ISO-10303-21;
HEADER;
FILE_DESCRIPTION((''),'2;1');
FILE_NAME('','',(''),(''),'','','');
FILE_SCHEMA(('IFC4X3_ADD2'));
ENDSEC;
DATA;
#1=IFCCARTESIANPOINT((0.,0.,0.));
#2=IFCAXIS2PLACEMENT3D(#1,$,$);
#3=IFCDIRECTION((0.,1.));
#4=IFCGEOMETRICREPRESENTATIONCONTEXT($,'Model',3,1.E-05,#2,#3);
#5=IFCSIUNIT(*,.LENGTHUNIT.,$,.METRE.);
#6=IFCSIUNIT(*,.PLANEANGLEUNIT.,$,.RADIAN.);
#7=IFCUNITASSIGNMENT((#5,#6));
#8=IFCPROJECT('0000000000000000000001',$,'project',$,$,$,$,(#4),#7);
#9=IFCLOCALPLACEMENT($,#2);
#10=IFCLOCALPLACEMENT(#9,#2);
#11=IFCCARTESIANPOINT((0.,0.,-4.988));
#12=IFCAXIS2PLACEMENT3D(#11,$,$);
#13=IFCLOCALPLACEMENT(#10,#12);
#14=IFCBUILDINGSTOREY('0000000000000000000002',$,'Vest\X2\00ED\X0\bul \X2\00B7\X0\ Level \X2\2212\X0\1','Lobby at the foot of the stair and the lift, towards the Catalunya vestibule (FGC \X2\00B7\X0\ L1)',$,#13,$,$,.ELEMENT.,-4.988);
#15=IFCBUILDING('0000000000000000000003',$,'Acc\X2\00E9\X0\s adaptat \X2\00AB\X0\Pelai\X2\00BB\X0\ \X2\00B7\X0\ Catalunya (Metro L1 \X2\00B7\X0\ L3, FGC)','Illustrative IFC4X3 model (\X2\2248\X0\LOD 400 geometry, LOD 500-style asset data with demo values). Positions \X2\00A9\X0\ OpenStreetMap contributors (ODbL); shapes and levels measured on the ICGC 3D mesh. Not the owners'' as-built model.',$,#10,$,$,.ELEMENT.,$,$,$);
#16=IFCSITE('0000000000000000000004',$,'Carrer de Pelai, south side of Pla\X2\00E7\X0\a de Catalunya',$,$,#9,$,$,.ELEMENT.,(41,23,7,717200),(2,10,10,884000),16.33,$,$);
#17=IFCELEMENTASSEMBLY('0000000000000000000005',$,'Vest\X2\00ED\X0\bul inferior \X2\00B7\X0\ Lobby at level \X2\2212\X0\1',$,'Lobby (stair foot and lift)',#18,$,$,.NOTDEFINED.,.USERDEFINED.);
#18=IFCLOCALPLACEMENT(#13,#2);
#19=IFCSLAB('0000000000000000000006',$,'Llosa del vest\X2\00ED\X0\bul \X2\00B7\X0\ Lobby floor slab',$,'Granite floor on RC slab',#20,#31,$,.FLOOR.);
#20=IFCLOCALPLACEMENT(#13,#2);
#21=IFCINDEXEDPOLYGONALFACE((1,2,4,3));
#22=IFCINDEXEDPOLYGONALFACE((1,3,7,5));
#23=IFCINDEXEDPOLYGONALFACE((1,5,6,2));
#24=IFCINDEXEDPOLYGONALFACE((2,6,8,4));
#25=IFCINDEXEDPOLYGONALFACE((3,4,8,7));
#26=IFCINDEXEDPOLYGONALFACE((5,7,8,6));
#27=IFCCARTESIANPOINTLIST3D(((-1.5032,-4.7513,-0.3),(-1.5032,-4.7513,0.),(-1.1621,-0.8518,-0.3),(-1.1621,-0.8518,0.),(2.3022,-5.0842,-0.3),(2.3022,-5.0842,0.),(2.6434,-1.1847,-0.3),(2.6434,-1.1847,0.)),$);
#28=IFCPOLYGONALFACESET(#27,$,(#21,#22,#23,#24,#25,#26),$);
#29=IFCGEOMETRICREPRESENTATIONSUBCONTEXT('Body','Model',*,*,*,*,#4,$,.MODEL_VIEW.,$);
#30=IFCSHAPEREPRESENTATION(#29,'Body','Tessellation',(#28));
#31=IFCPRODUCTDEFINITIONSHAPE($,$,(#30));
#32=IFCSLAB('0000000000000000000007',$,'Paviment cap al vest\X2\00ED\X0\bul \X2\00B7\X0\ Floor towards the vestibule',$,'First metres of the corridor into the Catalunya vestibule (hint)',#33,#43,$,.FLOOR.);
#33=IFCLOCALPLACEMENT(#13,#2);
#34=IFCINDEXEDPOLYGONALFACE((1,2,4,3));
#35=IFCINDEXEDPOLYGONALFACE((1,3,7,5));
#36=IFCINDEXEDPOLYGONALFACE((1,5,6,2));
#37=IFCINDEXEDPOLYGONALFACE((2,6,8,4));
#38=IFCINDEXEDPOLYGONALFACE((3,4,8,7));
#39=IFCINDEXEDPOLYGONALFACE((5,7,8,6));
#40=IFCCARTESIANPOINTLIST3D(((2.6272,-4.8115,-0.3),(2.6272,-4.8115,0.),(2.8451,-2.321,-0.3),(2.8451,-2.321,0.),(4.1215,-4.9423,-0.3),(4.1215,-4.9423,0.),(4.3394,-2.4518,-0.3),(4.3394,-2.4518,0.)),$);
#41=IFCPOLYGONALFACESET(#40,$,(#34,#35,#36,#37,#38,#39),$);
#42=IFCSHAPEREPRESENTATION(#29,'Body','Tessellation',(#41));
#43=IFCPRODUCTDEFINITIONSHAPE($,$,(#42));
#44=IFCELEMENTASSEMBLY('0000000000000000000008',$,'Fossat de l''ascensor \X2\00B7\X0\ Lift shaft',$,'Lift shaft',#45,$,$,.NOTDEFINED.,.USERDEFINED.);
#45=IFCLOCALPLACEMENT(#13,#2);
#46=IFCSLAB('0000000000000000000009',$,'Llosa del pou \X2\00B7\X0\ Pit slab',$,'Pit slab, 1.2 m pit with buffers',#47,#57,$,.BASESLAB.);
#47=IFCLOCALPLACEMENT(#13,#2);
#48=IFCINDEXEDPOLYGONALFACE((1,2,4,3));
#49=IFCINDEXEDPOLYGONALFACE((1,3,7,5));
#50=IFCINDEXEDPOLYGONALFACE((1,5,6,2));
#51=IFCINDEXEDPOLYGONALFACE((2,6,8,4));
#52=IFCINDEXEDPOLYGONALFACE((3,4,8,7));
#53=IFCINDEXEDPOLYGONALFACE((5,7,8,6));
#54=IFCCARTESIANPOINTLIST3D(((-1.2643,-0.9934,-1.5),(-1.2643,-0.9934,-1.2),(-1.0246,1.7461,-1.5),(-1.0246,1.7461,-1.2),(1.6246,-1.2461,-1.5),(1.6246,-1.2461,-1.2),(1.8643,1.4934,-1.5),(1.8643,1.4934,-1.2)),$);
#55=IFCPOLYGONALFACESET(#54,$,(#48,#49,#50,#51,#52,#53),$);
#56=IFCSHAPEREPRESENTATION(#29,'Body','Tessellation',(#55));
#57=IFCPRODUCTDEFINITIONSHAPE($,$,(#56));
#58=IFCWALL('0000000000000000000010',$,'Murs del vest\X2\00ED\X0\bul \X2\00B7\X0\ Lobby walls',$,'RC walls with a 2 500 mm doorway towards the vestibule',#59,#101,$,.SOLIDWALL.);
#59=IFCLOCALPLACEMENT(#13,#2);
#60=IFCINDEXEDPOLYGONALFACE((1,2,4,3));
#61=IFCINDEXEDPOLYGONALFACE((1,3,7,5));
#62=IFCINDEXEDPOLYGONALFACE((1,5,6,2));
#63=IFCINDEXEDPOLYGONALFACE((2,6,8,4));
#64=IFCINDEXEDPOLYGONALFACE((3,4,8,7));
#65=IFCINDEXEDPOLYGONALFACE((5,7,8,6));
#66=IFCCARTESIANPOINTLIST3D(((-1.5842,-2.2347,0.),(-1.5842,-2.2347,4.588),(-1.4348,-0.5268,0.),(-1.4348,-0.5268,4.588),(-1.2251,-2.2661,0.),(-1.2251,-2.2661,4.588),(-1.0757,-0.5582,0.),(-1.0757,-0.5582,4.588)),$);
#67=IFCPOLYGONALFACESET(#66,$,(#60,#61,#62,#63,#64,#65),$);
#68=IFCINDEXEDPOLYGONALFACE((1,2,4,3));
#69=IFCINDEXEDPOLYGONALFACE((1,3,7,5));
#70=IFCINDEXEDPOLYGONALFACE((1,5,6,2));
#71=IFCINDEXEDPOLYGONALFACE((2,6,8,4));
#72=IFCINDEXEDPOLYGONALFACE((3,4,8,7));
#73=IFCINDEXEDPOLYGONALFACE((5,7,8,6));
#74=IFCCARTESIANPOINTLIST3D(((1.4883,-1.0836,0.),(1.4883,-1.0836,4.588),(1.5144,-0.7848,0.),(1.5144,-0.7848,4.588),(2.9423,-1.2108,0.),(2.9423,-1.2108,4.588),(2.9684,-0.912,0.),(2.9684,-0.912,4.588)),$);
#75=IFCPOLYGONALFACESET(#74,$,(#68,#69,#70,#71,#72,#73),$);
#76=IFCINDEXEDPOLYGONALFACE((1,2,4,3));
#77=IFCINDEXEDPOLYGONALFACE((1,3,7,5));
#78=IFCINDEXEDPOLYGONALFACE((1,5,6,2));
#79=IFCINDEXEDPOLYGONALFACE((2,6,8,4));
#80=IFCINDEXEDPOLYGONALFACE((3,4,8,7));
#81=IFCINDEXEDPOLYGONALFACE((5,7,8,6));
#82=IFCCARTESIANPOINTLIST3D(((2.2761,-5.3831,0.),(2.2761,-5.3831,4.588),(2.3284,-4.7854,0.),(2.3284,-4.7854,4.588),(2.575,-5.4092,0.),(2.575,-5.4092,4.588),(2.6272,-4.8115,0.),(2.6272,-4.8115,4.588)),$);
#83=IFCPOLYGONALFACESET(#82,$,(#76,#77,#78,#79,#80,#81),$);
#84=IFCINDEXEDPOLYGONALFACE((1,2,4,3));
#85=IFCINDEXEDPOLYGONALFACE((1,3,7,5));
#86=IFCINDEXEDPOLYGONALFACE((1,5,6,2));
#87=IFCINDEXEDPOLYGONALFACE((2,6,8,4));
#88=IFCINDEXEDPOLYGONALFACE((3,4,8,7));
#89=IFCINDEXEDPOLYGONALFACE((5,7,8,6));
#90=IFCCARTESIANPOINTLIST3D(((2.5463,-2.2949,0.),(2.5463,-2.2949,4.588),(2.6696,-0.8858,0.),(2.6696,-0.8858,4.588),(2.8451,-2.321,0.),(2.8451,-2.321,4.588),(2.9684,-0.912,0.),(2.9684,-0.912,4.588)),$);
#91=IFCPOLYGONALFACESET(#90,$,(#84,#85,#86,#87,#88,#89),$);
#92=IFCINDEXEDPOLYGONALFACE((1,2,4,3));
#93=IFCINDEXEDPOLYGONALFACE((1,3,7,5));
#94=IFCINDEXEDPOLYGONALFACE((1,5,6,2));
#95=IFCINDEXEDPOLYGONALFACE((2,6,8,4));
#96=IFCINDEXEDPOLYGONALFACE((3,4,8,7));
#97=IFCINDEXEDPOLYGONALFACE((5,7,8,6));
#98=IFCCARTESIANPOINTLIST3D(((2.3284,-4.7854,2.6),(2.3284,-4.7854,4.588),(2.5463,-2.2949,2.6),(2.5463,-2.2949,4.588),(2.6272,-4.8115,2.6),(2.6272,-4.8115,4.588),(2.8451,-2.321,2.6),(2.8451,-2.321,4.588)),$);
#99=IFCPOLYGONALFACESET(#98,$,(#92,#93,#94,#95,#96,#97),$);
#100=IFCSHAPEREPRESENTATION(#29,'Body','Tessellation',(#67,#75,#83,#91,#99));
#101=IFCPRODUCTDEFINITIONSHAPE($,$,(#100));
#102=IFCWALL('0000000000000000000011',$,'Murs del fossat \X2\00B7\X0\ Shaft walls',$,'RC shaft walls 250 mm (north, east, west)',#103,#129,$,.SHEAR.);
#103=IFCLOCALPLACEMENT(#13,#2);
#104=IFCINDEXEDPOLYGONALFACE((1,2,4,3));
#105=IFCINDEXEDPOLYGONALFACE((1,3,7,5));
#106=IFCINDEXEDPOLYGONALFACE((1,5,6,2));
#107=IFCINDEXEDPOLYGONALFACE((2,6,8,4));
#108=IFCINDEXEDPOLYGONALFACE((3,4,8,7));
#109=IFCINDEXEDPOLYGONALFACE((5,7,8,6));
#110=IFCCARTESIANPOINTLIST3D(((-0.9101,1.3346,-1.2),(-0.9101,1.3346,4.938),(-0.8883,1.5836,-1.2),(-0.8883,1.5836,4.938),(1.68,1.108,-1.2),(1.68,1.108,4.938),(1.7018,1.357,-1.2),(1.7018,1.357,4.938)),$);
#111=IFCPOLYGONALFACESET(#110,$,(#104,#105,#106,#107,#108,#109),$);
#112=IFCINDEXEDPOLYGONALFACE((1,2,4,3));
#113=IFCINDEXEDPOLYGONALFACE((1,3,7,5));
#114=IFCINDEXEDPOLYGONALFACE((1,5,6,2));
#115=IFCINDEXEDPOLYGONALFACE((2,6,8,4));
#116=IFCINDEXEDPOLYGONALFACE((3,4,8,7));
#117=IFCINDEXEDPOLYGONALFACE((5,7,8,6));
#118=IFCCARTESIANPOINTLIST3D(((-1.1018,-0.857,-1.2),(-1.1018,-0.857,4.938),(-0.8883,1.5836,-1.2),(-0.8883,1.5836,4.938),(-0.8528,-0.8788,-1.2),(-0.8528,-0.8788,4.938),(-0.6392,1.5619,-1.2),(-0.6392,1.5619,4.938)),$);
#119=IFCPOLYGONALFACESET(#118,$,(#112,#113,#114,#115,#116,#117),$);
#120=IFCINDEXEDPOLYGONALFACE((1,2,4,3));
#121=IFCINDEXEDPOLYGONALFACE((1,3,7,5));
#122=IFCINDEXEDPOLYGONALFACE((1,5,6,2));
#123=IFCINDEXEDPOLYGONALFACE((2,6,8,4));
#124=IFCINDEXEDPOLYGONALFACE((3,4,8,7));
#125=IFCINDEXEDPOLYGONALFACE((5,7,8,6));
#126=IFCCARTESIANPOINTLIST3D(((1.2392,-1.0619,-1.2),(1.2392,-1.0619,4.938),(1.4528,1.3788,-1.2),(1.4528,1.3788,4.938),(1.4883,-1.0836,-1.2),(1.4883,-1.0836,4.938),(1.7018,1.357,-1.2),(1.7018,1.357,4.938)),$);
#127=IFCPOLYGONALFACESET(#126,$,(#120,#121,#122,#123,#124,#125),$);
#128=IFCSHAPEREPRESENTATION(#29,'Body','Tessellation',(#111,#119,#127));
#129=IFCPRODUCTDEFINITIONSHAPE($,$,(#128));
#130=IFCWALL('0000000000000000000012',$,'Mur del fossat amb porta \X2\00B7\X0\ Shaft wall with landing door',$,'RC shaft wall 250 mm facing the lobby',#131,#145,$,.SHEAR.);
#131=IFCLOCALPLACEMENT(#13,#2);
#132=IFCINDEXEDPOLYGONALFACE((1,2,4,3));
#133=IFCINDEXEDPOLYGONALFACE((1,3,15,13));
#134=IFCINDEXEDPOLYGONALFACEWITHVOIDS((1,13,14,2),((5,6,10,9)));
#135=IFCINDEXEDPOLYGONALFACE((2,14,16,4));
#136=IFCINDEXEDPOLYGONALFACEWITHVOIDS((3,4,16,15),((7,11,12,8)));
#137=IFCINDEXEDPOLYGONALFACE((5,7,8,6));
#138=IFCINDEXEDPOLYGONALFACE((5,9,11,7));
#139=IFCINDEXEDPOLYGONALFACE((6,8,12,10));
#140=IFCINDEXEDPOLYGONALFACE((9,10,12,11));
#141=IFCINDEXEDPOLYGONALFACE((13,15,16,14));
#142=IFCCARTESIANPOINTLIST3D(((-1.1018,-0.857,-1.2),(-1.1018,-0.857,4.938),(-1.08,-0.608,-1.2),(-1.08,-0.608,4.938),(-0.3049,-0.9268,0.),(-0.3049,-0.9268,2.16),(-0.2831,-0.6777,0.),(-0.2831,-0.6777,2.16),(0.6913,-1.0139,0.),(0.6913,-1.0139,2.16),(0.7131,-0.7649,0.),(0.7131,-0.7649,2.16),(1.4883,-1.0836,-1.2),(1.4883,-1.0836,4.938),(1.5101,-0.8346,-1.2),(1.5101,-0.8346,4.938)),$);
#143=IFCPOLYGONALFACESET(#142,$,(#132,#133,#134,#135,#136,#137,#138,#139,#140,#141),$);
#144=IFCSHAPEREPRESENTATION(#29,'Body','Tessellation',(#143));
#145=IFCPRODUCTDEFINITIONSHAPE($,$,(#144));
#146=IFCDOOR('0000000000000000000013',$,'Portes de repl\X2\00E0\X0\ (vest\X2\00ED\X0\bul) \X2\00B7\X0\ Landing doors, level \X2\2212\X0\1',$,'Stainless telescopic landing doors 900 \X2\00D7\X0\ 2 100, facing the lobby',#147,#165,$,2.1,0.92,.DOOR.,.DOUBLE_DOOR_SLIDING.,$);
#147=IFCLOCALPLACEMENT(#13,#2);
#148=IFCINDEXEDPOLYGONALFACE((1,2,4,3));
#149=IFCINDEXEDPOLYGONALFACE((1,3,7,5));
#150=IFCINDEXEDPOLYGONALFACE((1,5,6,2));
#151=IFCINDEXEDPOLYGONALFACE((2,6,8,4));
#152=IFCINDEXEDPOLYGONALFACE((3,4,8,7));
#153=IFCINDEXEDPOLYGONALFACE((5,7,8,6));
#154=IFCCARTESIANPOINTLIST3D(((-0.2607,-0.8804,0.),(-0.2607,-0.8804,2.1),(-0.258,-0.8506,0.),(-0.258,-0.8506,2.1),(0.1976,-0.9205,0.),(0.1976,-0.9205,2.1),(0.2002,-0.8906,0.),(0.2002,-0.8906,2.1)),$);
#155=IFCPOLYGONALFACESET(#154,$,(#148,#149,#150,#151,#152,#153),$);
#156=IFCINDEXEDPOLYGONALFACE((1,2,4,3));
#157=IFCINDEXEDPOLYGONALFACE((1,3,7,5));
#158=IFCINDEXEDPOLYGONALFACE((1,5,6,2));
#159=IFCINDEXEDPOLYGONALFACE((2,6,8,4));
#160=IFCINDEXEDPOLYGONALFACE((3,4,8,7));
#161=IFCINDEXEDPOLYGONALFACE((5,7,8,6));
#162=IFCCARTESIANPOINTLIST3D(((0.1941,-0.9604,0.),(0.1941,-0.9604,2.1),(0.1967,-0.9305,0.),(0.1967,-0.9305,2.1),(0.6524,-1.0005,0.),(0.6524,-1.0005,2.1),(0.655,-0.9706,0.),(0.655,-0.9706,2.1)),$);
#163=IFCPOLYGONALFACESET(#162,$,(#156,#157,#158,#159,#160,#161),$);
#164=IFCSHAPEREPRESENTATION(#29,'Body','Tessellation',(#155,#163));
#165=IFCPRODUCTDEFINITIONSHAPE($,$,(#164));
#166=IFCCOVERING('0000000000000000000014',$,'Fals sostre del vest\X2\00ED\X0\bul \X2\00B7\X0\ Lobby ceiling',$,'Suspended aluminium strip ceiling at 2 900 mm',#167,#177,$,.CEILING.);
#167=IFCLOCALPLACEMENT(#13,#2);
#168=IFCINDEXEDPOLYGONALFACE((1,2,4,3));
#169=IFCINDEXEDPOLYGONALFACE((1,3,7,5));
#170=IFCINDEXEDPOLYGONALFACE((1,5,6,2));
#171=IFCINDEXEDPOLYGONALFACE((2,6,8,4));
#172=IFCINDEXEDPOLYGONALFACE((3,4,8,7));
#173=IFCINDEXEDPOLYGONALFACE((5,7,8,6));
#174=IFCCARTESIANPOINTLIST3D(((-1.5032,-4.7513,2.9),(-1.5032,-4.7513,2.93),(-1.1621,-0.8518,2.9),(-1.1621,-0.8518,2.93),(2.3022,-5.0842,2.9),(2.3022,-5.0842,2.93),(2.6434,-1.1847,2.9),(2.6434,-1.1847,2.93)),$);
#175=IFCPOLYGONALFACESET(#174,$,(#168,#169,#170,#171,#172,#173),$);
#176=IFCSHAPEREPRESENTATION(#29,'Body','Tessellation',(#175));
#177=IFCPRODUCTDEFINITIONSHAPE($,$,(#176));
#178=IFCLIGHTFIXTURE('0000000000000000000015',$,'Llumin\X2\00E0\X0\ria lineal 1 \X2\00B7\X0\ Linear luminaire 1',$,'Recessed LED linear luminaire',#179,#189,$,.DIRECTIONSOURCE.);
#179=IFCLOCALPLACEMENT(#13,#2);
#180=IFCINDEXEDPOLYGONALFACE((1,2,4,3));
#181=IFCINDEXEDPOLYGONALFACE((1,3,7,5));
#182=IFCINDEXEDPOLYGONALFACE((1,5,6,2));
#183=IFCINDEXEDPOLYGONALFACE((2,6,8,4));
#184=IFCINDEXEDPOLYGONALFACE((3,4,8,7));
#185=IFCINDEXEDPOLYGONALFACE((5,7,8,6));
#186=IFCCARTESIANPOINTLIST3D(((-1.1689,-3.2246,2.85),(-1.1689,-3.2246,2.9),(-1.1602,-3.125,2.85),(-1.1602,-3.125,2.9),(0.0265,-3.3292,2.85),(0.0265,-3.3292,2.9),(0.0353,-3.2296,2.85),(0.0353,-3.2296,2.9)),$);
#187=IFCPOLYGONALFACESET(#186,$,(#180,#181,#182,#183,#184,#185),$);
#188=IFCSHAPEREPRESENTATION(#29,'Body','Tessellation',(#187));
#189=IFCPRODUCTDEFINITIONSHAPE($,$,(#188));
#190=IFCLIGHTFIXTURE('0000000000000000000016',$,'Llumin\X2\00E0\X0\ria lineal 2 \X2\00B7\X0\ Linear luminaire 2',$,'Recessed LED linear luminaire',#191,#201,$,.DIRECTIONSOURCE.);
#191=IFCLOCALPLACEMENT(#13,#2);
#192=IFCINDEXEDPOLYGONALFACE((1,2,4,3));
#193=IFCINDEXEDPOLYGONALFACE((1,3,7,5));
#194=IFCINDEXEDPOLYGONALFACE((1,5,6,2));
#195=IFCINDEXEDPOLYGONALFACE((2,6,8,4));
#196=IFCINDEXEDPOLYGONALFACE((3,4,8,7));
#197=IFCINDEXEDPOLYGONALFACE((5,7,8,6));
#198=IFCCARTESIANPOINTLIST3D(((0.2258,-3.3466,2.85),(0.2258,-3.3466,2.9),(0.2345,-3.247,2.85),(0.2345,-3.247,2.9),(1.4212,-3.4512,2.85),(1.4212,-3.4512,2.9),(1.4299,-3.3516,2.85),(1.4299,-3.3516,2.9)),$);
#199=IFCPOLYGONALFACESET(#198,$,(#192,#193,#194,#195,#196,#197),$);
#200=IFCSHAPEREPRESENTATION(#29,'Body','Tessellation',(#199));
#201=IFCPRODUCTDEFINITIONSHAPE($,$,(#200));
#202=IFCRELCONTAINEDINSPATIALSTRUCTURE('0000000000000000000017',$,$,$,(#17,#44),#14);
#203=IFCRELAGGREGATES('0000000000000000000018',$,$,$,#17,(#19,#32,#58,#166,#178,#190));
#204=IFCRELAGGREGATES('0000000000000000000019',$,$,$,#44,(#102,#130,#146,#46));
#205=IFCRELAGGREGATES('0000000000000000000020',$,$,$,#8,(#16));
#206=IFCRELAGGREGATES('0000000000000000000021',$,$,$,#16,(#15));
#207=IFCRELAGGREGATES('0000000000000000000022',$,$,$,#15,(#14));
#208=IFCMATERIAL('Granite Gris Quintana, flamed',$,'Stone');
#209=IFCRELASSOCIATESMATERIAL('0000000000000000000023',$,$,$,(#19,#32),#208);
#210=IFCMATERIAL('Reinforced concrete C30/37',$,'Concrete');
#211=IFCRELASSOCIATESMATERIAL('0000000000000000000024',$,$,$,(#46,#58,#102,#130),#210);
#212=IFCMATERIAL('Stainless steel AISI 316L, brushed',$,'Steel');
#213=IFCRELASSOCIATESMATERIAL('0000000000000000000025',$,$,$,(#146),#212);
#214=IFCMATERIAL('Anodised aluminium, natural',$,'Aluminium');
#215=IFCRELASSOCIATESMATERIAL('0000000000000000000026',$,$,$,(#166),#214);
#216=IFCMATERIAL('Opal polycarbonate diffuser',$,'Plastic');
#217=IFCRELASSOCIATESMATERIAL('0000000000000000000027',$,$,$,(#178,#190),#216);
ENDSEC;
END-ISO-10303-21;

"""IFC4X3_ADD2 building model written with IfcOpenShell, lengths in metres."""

from ifc_helpers import new_model, si_unit, direction, frame, frame_2d, origin, place, context, subcontext, project, spatial, polyline, rectangle, outline, extrude, material, element, fill, aggregate, save


model = new_model("IFC4X3_ADD2")

# Units and contexts
model_context = context("Model", 3, precision=1e-05, world=origin(), true_north=direction((0.0, 1.0)))
body_context = subcontext(model_context, "Body", "Model", "MODEL_VIEW")
ifc_project = project(units=[si_unit("LENGTHUNIT", "METRE"), si_unit("PLANEANGLEUNIT", "RADIAN")], contexts=[model_context])

# Site, building, storey
site_placement = place(None, origin())
site = spatial("IfcSite", under=ifc_project, at=site_placement, Name="Carrer de Pelai, south side of Plaça de Catalunya", CompositionType="ELEMENT", RefLatitude=(41, 23, 7, 717200), RefLongitude=(2, 10, 10, 884000), RefElevation=16.33)
building_placement = place(site_placement, origin())
building = spatial("IfcBuilding", under=site, at=building_placement, Name="Accés adaptat «Pelai» · Catalunya (Metro L1 · L3, FGC)", Description="Illustrative IFC4X3 model (≈LOD 400 geometry, LOD 500-style asset data with demo values). Positions © OpenStreetMap contributors (ODbL); shapes and levels measured on the ICGC 3D mesh. Not the owners' as-built model.", CompositionType="ELEMENT")
storey_placement = place(building_placement, frame((0.0, 0.0, -4.988)))
storey = spatial("IfcBuildingStorey", under=building, at=storey_placement, Name="Vestíbul · Level −1", Description="Lobby at the foot of the stair and the lift, towards the Catalunya vestibule (FGC · L1)", CompositionType="ELEMENT", Elevation=-4.988)

# Element assembly, slabs
assembly_1_placement = place(building_placement, origin())
assembly_1 = element("IfcElementAssembly", 1, at=assembly_1_placement, inside=storey, Name="Vestíbul inferior · Lobby at level −1", ObjectType="Lobby (stair foot and lift)", AssemblyPlace="NOTDEFINED", PredefinedType="USERDEFINED")
ifc_material_1 = material(Name="Granite Gris Quintana, flamed", Category="Stone")
slab_1_placement = place(building_placement, origin())
slab_1 = element("IfcSlab", 2, at=slab_1_placement, material=ifc_material_1, Name="Llosa del vestíbul · Lobby floor slab", ObjectType="Granite floor on RC slab", PredefinedType="FLOOR", context=body_context, shape_type="SweptSolid", body=[
    extrude(outline(polyline([(-1.5032, -4.7513), (2.3022, -5.0842), (2.6434, -1.1847), (-1.1621, -0.8518), (-1.5032, -4.7513)])), frame((0.0, 0.0, -5.288)), (0.0, 0.0, 1.0), 0.3),
])
slab_2_placement = place(building_placement, origin())
slab_2 = element("IfcSlab", 3, at=slab_2_placement, material=ifc_material_1, Name="Paviment cap al vestíbul · Floor towards the vestibule", ObjectType="First metres of the corridor into the Catalunya vestibule (hint)", PredefinedType="FLOOR", context=body_context, shape_type="SweptSolid", body=[
    extrude(rectangle(XDim=1.5, YDim=2.5, at=frame_2d((0.0, 0.0), x_axis=(0.996195, -0.087156))), frame((3.4833, -3.6316, -5.288)), (0.0, 0.0, 1.0), 0.3),
])

# Element assembly, slab
assembly_2_placement = place(building_placement, origin())
assembly_2 = element("IfcElementAssembly", 4, at=assembly_2_placement, inside=storey, Name="Fossat de l'ascensor · Lift shaft", ObjectType="Lift shaft", AssemblyPlace="NOTDEFINED", PredefinedType="USERDEFINED")
ifc_material_2 = material(Name="Reinforced concrete C30/37", Category="Concrete")
slab_3_placement = place(building_placement, origin())
slab_3 = element("IfcSlab", 5, at=slab_3_placement, material=ifc_material_2, Name="Llosa del pou · Pit slab", ObjectType="Pit slab, 1.2 m pit with buffers", PredefinedType="BASESLAB", context=body_context, shape_type="SweptSolid", body=[
    extrude(rectangle(XDim=2.9, YDim=2.75, at=frame_2d((0.0, 0.0), x_axis=(0.996195, -0.087156))), frame((0.3, 0.25, -6.488)), (0.0, 0.0, 1.0), 0.3),
])

# Walls
wall_1_placement = place(building_placement, origin())
wall_1 = element("IfcWall", 6, at=wall_1_placement, material=ifc_material_2, Name="Murs del vestíbul · Lobby walls", ObjectType="RC walls with a 2 500 mm doorway towards the vestibule", PredefinedType="SOLIDWALL", context=body_context, shape_type="SweptSolid", body=[
    extrude(rectangle(XDim=0.3605, YDim=1.7144, at=frame_2d((0.0, 0.0), x_axis=(0.996195, -0.087156))), frame((-1.3299, -1.3964, -4.988)), (0.0, 0.0, 1.0), 4.588),
    extrude(rectangle(XDim=1.4595, YDim=0.3, at=frame_2d((0.0, 0.0), x_axis=(0.996195, -0.087156))), frame((2.2283, -0.9978, -4.988)), (0.0, 0.0, 1.0), 4.588),
    extrude(rectangle(XDim=0.3, YDim=0.6, at=frame_2d((0.0, 0.0), x_axis=(0.996195, -0.087156))), frame((2.4517, -5.0973, -4.988)), (0.0, 0.0, 1.0), 4.588),
    extrude(rectangle(XDim=0.3, YDim=1.4144, at=frame_2d((0.0, 0.0), x_axis=(0.996195, -0.087156))), frame((2.7573, -1.6034, -4.988)), (0.0, 0.0, 1.0), 4.588),
    extrude(rectangle(XDim=0.3, YDim=2.5, at=frame_2d((0.0, 0.0), x_axis=(0.996195, -0.087156))), frame((2.5868, -3.5532, -2.388)), (0.0, 0.0, 1.0), 1.988),
])
wall_2_placement = place(building_placement, origin())
wall_2 = element("IfcWall", 7, at=wall_2_placement, material=ifc_material_2, Name="Murs del fossat · Shaft walls", ObjectType="RC shaft walls 250 mm (north, east, west)", PredefinedType="SHEAR", context=body_context, shape_type="SweptSolid", body=[
    extrude(rectangle(XDim=2.6, YDim=0.25, at=frame_2d((0.0, 0.0), x_axis=(0.996195, -0.087156))), frame((0.3959, 1.3458, -6.188)), (0.0, 0.0, 1.0), 6.138),
    extrude(rectangle(XDim=0.25, YDim=2.45, at=frame_2d((0.0, 0.0), x_axis=(0.996195, -0.087156))), frame((-0.8705, 0.3524, -6.188)), (0.0, 0.0, 1.0), 6.138),
    extrude(rectangle(XDim=0.25, YDim=2.45, at=frame_2d((0.0, 0.0), x_axis=(0.996195, -0.087156))), frame((1.4705, 0.1476, -6.188)), (0.0, 0.0, 1.0), 6.138),
])

# Wall, opening, door
wall_3_placement = place(building_placement, origin())
wall_3 = element("IfcWall", 8, at=wall_3_placement, material=ifc_material_2, Name="Mur del fossat amb porta · Shaft wall with landing door", ObjectType="RC shaft wall 250 mm facing the lobby", PredefinedType="SHEAR", context=body_context, shape_type="SweptSolid", body=[
    extrude(rectangle(XDim=2.6, YDim=0.25, at=frame_2d((0.0, 0.0), x_axis=(0.996195, -0.087156))), frame((0.2041, -0.8458, -6.188)), (0.0, 0.0, 1.0), 6.138),
])
opening_placement = place(building_placement, origin())
opening = element("IfcOpeningElement", 9, at=opening_placement, cuts=wall_3, PredefinedType="OPENING", context=body_context, shape_type="SweptSolid", body=[
    extrude(rectangle(XDim=1.0, YDim=0.35, at=frame_2d((0.0, 0.0), x_axis=(0.996195, -0.087156))), frame((0.2041, -0.8458, -4.988)), (0.0, 0.0, 1.0), 2.16),
])
ifc_material_3 = material(Name="Stainless steel AISI 316L, brushed", Category="Steel")
door_placement = place(building_placement, origin())
door = element("IfcDoor", 10, at=door_placement, material=ifc_material_3, Name="Portes de replà (vestíbul) · Landing doors, level −1", ObjectType="Stainless telescopic landing doors 900 × 2 100, facing the lobby", OperationType="DOUBLE_DOOR_SLIDING", OverallHeight=2.1, OverallWidth=0.92, PredefinedType="DOOR", context=body_context, shape_type="SweptSolid", body=[
    extrude(rectangle(XDim=0.46, YDim=0.03, at=frame_2d((0.0, 0.0), x_axis=(0.996195, -0.087156))), frame((-0.0302, -0.8855, -4.988)), (0.0, 0.0, 1.0), 2.1),
    extrude(rectangle(XDim=0.46, YDim=0.03, at=frame_2d((0.0, 0.0), x_axis=(0.996195, -0.087156))), frame((0.4245, -0.9655, -4.988)), (0.0, 0.0, 1.0), 2.1),
])
fill(opening, door)

# Covering
ifc_material_4 = material(Name="Anodised aluminium, natural", Category="Aluminium")
covering_placement = place(building_placement, origin())
covering = element("IfcCovering", 11, at=covering_placement, material=ifc_material_4, Name="Fals sostre del vestíbul · Lobby ceiling", ObjectType="Suspended aluminium strip ceiling at 2 900 mm", PredefinedType="CEILING", context=body_context, shape_type="SweptSolid", body=[
    extrude(outline(polyline([(-1.5032, -4.7513), (2.3022, -5.0842), (2.6434, -1.1847), (-1.1621, -0.8518), (-1.5032, -4.7513)])), frame((0.0, 0.0, -2.088)), (0.0, 0.0, 1.0), 0.03),
])

# Light fixtures
ifc_material_5 = material(Name="Opal polycarbonate diffuser", Category="Plastic")
light_fixture_1_placement = place(building_placement, origin())
light_fixture_1 = element("IfcLightFixture", 12, at=light_fixture_1_placement, material=ifc_material_5, Name="Lluminària lineal 1 · Linear luminaire 1", ObjectType="Recessed LED linear luminaire", PredefinedType="DIRECTIONSOURCE", context=body_context, shape_type="SweptSolid", body=[
    extrude(rectangle(XDim=1.2, YDim=0.1, at=frame_2d((0.0, 0.0), x_axis=(0.996195, -0.087156))), frame((-0.5668, -3.2271, -2.138)), (0.0, 0.0, 1.0), 0.05),
])
light_fixture_2_placement = place(building_placement, origin())
light_fixture_2 = element("IfcLightFixture", 13, at=light_fixture_2_placement, material=ifc_material_5, Name="Lluminària lineal 2 · Linear luminaire 2", ObjectType="Recessed LED linear luminaire", PredefinedType="DIRECTIONSOURCE", context=body_context, shape_type="SweptSolid", body=[
    extrude(rectangle(XDim=1.2, YDim=0.1, at=frame_2d((0.0, 0.0), x_axis=(0.996195, -0.087156))), frame((0.8279, -3.3491, -2.138)), (0.0, 0.0, 1.0), 0.05),
])

aggregate(assembly_1, [slab_1, slab_2, wall_1, covering, light_fixture_1, light_fixture_2])

aggregate(assembly_2, [wall_2, wall_3, door, slab_3])

save(model, "model.ifc")
